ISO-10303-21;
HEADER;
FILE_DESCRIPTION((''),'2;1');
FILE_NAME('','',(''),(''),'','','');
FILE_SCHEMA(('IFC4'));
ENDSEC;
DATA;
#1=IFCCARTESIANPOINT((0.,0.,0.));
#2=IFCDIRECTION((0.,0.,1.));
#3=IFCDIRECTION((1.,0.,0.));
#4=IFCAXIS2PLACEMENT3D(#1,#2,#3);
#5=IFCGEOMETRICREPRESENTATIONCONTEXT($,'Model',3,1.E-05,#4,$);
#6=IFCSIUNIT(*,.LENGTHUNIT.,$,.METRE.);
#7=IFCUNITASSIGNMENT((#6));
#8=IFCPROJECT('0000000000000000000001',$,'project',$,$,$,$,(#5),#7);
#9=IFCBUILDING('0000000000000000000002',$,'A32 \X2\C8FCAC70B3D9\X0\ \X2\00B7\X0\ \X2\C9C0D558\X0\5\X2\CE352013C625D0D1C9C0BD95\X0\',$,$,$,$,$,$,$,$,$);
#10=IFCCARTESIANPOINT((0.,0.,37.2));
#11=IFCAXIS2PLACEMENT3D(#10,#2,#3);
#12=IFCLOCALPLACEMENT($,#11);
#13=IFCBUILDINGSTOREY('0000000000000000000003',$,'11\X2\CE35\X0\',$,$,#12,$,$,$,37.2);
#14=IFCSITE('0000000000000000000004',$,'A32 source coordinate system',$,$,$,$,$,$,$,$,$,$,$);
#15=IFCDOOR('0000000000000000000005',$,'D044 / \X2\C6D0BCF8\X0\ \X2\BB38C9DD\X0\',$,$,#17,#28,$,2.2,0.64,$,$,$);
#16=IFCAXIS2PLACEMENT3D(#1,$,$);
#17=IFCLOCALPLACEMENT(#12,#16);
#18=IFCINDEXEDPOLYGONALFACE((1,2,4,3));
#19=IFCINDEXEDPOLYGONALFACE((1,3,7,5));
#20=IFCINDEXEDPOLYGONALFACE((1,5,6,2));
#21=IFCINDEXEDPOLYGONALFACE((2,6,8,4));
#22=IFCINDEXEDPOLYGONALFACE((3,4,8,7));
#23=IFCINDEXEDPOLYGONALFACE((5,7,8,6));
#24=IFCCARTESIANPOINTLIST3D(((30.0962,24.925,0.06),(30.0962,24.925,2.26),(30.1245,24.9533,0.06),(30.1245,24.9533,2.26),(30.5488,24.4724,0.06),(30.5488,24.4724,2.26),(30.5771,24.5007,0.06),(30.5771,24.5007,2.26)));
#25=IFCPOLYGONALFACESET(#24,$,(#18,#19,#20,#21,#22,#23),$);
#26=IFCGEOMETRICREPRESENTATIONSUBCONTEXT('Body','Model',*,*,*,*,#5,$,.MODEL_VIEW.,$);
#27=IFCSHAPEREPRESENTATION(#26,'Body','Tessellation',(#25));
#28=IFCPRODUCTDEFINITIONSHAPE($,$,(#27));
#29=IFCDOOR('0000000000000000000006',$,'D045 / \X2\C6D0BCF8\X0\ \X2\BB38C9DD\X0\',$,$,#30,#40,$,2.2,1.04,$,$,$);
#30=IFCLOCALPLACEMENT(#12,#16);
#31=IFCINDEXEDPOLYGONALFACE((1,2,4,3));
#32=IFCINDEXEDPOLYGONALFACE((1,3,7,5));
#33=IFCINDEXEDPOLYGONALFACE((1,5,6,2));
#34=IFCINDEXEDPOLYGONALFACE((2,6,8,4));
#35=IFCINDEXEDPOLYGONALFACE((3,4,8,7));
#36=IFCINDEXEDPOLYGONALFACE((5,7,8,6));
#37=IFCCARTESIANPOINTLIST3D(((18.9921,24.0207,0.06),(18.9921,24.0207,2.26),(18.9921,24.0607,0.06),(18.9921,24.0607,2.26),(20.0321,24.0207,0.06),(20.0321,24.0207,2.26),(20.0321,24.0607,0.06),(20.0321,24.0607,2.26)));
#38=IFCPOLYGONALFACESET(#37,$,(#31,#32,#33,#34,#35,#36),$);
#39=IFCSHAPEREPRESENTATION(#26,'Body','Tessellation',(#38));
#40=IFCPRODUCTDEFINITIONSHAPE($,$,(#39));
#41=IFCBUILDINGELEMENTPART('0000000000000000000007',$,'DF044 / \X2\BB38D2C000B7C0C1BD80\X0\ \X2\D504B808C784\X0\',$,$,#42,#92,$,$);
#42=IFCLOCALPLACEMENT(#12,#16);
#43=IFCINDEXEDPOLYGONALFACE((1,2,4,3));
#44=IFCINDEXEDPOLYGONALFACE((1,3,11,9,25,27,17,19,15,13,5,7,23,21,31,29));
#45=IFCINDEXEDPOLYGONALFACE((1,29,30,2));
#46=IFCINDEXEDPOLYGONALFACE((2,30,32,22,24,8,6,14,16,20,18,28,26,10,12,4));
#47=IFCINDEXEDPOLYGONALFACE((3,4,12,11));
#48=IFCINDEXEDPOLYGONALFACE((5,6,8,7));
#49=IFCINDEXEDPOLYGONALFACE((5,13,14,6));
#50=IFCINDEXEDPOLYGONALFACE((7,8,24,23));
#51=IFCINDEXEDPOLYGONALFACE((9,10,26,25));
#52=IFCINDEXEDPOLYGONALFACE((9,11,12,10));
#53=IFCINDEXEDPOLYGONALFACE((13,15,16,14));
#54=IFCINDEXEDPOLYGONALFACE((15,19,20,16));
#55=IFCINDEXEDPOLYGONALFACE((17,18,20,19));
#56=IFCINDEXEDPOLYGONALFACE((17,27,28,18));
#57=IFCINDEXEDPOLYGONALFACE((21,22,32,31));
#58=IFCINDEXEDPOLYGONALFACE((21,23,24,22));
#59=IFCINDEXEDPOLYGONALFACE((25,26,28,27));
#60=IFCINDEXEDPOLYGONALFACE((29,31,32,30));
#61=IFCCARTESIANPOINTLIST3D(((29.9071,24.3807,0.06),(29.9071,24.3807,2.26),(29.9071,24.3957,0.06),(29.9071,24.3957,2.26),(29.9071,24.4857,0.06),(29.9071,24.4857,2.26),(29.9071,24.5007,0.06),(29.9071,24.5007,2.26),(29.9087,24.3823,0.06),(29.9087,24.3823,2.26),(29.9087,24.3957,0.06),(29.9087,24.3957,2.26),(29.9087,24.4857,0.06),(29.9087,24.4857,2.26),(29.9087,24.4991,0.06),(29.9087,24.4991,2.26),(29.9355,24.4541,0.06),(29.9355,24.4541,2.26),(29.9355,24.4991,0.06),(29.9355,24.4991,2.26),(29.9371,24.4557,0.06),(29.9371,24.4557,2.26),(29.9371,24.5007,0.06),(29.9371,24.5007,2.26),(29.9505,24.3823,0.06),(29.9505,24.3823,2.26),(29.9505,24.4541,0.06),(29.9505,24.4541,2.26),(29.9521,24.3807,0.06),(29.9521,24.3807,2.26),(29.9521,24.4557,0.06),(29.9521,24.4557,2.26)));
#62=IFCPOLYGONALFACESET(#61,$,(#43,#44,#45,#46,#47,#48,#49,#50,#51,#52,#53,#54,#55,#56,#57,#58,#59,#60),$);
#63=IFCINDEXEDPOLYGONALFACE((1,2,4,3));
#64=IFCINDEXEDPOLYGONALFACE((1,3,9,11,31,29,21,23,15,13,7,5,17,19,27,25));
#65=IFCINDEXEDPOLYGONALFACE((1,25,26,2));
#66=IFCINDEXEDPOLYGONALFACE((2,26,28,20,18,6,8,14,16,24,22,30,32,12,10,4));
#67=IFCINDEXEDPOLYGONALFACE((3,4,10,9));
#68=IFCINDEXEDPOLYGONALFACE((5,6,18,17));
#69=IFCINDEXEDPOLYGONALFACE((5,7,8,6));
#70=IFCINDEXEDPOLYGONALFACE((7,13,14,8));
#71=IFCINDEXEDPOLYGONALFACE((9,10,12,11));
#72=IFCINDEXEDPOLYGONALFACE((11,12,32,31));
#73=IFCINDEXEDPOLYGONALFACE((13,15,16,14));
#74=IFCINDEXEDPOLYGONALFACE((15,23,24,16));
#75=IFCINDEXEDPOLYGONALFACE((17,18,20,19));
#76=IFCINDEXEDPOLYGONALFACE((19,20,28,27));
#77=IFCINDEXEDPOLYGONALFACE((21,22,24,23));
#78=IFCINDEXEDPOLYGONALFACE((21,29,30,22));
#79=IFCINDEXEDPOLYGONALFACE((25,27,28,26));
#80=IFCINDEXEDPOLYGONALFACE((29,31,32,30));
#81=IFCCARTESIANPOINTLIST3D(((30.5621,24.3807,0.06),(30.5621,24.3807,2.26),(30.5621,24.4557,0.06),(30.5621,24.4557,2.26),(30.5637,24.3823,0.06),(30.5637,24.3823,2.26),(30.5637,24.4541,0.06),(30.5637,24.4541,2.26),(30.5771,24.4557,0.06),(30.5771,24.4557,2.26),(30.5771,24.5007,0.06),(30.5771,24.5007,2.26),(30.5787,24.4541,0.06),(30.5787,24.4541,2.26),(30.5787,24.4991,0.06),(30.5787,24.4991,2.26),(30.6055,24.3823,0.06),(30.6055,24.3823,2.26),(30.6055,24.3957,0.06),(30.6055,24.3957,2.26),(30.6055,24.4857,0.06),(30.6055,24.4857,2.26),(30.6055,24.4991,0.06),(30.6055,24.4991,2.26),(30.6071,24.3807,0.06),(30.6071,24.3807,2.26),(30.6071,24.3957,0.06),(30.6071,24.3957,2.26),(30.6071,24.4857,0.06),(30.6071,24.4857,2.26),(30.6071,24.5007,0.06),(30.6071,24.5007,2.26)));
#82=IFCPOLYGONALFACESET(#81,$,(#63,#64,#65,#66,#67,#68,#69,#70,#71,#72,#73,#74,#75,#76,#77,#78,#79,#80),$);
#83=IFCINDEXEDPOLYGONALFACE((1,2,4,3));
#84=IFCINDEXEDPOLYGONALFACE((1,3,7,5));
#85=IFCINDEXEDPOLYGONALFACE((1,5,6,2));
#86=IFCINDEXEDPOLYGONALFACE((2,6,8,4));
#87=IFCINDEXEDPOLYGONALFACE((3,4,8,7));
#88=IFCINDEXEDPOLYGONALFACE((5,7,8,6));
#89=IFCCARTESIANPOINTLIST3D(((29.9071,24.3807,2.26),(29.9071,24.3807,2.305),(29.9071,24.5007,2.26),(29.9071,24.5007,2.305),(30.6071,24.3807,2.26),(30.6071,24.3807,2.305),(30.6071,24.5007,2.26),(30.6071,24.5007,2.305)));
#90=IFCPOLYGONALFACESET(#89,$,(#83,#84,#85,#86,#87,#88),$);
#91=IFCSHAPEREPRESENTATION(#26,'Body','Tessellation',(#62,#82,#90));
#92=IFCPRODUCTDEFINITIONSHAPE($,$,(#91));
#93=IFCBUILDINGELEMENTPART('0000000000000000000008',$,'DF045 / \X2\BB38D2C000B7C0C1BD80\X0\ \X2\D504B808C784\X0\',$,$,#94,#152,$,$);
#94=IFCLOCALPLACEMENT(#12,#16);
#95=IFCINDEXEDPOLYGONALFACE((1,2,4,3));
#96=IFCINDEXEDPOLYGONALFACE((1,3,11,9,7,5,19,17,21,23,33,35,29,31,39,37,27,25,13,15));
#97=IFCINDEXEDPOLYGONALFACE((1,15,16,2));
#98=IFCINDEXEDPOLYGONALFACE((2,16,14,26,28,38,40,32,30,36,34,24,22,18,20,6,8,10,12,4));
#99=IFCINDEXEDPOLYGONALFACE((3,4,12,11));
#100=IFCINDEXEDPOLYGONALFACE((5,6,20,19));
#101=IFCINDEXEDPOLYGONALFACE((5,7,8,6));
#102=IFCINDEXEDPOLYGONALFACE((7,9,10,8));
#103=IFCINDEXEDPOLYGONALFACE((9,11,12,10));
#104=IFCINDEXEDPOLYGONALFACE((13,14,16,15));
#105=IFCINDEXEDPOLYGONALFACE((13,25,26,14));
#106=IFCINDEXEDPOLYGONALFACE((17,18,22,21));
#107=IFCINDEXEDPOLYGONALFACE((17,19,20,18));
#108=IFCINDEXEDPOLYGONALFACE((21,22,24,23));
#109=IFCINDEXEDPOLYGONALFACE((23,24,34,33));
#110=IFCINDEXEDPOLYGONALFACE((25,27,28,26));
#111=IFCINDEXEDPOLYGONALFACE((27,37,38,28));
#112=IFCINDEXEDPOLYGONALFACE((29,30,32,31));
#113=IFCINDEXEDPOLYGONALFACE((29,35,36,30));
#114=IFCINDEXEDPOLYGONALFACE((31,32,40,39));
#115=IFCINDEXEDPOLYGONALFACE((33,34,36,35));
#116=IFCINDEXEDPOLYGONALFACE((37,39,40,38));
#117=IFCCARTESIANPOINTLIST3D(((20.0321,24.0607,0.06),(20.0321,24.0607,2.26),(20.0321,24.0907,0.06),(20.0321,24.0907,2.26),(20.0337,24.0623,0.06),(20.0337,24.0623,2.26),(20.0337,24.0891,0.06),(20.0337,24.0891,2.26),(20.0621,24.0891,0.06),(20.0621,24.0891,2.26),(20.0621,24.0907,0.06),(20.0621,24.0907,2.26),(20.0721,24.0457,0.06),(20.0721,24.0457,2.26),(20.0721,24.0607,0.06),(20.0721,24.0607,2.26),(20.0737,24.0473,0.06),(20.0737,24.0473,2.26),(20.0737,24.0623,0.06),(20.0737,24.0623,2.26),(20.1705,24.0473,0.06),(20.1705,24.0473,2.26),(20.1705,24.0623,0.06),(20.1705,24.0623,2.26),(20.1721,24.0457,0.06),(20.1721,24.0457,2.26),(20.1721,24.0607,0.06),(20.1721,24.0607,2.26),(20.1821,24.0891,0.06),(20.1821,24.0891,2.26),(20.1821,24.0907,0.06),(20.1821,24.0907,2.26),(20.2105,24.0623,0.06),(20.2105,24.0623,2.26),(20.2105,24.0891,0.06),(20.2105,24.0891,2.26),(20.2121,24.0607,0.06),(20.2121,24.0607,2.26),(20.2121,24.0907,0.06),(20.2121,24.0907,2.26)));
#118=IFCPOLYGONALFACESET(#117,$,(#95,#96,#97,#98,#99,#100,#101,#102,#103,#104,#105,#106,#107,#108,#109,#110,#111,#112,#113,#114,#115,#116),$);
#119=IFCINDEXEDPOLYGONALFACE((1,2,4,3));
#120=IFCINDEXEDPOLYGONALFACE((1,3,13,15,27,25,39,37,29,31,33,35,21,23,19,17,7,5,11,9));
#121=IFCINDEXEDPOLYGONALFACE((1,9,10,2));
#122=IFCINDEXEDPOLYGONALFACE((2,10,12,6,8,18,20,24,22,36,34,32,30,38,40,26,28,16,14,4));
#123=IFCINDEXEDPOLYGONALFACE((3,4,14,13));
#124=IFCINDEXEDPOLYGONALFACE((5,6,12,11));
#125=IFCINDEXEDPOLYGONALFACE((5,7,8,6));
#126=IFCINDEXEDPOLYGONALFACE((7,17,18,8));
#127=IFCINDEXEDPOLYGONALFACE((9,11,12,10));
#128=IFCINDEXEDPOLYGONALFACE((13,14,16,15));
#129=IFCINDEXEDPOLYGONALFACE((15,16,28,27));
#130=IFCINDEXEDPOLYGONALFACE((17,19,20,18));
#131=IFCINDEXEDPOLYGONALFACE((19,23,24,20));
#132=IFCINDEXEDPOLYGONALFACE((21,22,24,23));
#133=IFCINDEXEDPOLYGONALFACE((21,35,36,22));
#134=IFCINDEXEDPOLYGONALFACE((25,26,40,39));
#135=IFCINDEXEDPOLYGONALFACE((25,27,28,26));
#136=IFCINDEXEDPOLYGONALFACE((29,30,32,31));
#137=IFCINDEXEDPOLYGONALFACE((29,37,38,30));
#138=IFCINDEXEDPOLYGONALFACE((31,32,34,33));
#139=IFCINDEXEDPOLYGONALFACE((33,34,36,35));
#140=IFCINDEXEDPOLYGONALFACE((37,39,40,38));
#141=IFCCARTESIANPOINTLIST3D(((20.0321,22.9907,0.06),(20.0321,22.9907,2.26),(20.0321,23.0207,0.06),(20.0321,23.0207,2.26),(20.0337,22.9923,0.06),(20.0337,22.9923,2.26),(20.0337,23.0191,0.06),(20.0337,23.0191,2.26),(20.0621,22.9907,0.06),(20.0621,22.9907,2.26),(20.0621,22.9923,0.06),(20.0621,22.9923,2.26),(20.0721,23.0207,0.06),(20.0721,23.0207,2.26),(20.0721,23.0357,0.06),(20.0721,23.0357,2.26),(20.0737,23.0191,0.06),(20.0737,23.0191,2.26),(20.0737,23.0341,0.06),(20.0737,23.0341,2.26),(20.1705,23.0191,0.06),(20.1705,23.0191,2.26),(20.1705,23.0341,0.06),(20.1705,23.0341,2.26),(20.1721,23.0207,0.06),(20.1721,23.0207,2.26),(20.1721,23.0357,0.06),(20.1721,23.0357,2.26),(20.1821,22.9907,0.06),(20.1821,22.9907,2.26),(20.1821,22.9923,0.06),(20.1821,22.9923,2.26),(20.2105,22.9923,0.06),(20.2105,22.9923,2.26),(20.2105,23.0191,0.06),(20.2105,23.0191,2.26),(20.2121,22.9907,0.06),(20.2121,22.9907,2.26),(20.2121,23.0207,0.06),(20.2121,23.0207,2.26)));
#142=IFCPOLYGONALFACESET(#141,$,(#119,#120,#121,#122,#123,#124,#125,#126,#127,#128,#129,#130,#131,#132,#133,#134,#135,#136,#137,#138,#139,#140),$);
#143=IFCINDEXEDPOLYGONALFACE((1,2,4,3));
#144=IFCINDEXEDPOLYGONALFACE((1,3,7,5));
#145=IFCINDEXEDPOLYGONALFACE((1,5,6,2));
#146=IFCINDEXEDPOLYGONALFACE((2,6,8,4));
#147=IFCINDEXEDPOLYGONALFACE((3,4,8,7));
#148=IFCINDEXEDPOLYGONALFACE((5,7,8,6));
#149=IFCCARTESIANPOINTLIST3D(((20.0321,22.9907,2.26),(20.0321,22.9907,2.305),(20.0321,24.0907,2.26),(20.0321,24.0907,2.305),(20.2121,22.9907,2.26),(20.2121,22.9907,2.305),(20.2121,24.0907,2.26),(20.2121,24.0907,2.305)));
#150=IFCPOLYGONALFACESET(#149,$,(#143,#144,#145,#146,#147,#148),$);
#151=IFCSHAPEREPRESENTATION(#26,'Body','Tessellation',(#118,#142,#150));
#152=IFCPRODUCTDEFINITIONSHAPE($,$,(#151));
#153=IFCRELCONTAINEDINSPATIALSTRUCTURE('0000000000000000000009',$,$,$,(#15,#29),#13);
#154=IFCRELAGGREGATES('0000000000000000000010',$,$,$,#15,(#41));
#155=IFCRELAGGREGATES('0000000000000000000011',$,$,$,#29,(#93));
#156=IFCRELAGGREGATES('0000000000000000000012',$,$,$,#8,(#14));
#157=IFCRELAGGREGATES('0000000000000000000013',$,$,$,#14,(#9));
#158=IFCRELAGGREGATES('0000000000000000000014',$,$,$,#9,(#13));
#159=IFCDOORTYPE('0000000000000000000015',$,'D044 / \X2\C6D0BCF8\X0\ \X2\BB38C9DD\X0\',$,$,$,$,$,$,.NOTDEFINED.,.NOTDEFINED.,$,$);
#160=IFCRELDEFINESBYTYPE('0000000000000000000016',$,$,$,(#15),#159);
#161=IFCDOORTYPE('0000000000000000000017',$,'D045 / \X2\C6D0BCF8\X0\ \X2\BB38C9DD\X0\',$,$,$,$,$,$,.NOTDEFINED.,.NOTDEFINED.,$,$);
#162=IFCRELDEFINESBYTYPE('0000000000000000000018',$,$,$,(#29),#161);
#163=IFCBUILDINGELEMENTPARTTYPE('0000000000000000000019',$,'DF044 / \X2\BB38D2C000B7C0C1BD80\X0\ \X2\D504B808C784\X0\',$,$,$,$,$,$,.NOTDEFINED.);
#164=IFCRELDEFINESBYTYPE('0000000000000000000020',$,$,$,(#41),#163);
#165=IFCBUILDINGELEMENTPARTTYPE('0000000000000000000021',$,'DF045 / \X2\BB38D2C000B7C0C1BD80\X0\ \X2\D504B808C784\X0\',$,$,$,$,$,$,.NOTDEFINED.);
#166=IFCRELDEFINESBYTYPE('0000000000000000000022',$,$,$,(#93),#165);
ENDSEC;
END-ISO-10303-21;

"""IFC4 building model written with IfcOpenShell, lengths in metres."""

from ifc_helpers import new_model, si_unit, frame, origin, origin_with_axes, place, context, subcontext, project, spatial, polyline, outline, extrude, source, transform, mapped, type_object, type_shapes, element, aggregate, save


model = new_model("IFC4")

# Units and contexts
model_context = context("Model", 3, precision=1e-05, world=origin_with_axes())
body_context = subcontext(model_context, "Body", "Model", "MODEL_VIEW")
ifc_project = project(units=[si_unit("LENGTHUNIT", "METRE")], contexts=[model_context])

# Site, building, storey
storey_placement = place(None, frame((0.0, 0.0, 37.2), z_axis=(0.0, 0.0, 1.0), x_axis=(1.0, 0.0, 0.0)))
site = spatial("IfcSite", under=ifc_project, Name="A32 source coordinate system")
building = spatial("IfcBuilding", under=site, Name="A32 주거동 · 지하5층–옥탑지붕")
storey = spatial("IfcBuildingStorey", under=building, at=storey_placement, Name="11층", Elevation=37.2)

# Doors
door_type_1 = type_object("IfcDoorType", Name="D044 / 원본 문짝", OperationType="NOTDEFINED", PredefinedType="NOTDEFINED")
shared_shape_1 = source(origin(), body_context, "Body", "SweptSolid", [
    extrude(outline(polyline([(30.5771, 24.5007), (30.5488, 24.4724), (30.0962, 24.925), (30.1245, 24.9533), (30.5771, 24.5007)])), frame((0.0, 0.0, 0.06)), (0.0, 0.0, 1.0), 2.2),
])
type_shapes(door_type_1, [shared_shape_1])
door_1_placement = place(storey_placement, origin_with_axes())
door_1 = element("IfcDoor", 1, at=door_1_placement, inside=storey, type_object=door_type_1, Name="D044 / 원본 문짝", OverallHeight=2.2, OverallWidth=0.64, context=body_context, shape_type="MappedRepresentation", body=[
    mapped(shared_shape_1, transform((0.0, 0.0, 0.0), scale=1.0)),
])
door_type_2 = type_object("IfcDoorType", Name="D045 / 원본 문짝", OperationType="NOTDEFINED", PredefinedType="NOTDEFINED")
shared_shape_2 = source(origin(), body_context, "Body", "SweptSolid", [
    extrude(outline(polyline([(20.0321, 24.0607), (20.0321, 24.0207), (18.9921, 24.0207), (18.9921, 24.0607), (20.0321, 24.0607)])), frame((0.0, 0.0, 0.06)), (0.0, 0.0, 1.0), 2.2),
])
type_shapes(door_type_2, [shared_shape_2])
door_2_placement = place(storey_placement, origin_with_axes())
door_2 = element("IfcDoor", 2, at=door_2_placement, inside=storey, type_object=door_type_2, Name="D045 / 원본 문짝", OverallHeight=2.2, OverallWidth=1.04, context=body_context, shape_type="MappedRepresentation", body=[
    mapped(shared_shape_2, transform((0.0, 0.0, 0.0), scale=1.0)),
])

# Building element parts
building_element_part_type_1 = type_object("IfcBuildingElementPartType", Name="DF044 / 문틀·상부 프레임", PredefinedType="NOTDEFINED")
shared_shape_3 = source(origin(), body_context, "Body", "SweptSolid", [
    extrude(outline(polyline([(29.9071, 24.4857), (29.9071, 24.5007), (29.9371, 24.5007), (29.9371, 24.4557), (29.9521, 24.4557), (29.9521, 24.3807), (29.9071, 24.3807), (29.9071, 24.3957), (29.9087, 24.3957), (29.9087, 24.3823), (29.9505, 24.3823), (29.9505, 24.4541), (29.9355, 24.4541), (29.9355, 24.4991), (29.9087, 24.4991), (29.9087, 24.4857), (29.9071, 24.4857)])), frame((0.0, 0.0, 0.06)), (0.0, 0.0, 1.0), 2.2),
    extrude(outline(polyline([(30.6055, 24.4991), (30.5787, 24.4991), (30.5787, 24.4541), (30.5637, 24.4541), (30.5637, 24.3823), (30.6055, 24.3823), (30.6055, 24.3957), (30.6071, 24.3957), (30.6071, 24.3807), (30.5621, 24.3807), (30.5621, 24.4557), (30.5771, 24.4557), (30.5771, 24.5007), (30.6071, 24.5007), (30.6071, 24.4857), (30.6055, 24.4857), (30.6055, 24.4991)])), frame((0.0, 0.0, 0.06)), (0.0, 0.0, 1.0), 2.2),
    extrude(outline(polyline([(29.9071, 24.3807), (29.9071, 24.5007), (30.6071, 24.5007), (30.6071, 24.3807), (29.9071, 24.3807)])), frame((0.0, 0.0, 2.26)), (0.0, 0.0, 1.0), 0.045),
])
type_shapes(building_element_part_type_1, [shared_shape_3])
building_element_part_1_placement = place(door_1_placement, origin_with_axes())
building_element_part_1 = element("IfcBuildingElementPart", 3, at=building_element_part_1_placement, type_object=building_element_part_type_1, Name="DF044 / 문틀·상부 프레임", context=body_context, shape_type="MappedRepresentation", body=[
    mapped(shared_shape_3, transform((0.0, 0.0, 0.0), scale=1.0)),
])
aggregate(door_1, [building_element_part_1])
building_element_part_type_2 = type_object("IfcBuildingElementPartType", Name="DF045 / 문틀·상부 프레임", PredefinedType="NOTDEFINED")
shared_shape_4 = source(origin(), body_context, "Body", "SweptSolid", [
    extrude(outline(polyline([(20.0337, 24.0891), (20.0337, 24.0623), (20.0737, 24.0623), (20.0737, 24.0473), (20.1705, 24.0473), (20.1705, 24.0623), (20.2105, 24.0623), (20.2105, 24.0891), (20.1821, 24.0891), (20.1821, 24.0907), (20.2121, 24.0907), (20.2121, 24.0607), (20.1721, 24.0607), (20.1721, 24.0457), (20.0721, 24.0457), (20.0721, 24.0607), (20.0321, 24.0607), (20.0321, 24.0907), (20.0621, 24.0907), (20.0621, 24.0891), (20.0337, 24.0891)])), frame((0.0, 0.0, 0.06)), (0.0, 0.0, 1.0), 2.2),
    extrude(outline(polyline([(20.0621, 22.9907), (20.0321, 22.9907), (20.0321, 23.0207), (20.0721, 23.0207), (20.0721, 23.0357), (20.1721, 23.0357), (20.1721, 23.0207), (20.2121, 23.0207), (20.2121, 22.9907), (20.1821, 22.9907), (20.1821, 22.9923), (20.2105, 22.9923), (20.2105, 23.0191), (20.1705, 23.0191), (20.1705, 23.0341), (20.0737, 23.0341), (20.0737, 23.0191), (20.0337, 23.0191), (20.0337, 22.9923), (20.0621, 22.9923), (20.0621, 22.9907)])), frame((0.0, 0.0, 0.06)), (0.0, 0.0, 1.0), 2.2),
    extrude(outline(polyline([(20.0321, 22.9907), (20.0321, 24.0907), (20.2121, 24.0907), (20.2121, 22.9907), (20.0321, 22.9907)])), frame((0.0, 0.0, 2.26)), (0.0, 0.0, 1.0), 0.045),
])
type_shapes(building_element_part_type_2, [shared_shape_4])
building_element_part_2_placement = place(door_2_placement, origin_with_axes())
building_element_part_2 = element("IfcBuildingElementPart", 4, at=building_element_part_2_placement, type_object=building_element_part_type_2, Name="DF045 / 문틀·상부 프레임", context=body_context, shape_type="MappedRepresentation", body=[
    mapped(shared_shape_4, transform((0.0, 0.0, 0.0), scale=1.0)),
])
aggregate(door_2, [building_element_part_2])

save(model, "model.ifc")
